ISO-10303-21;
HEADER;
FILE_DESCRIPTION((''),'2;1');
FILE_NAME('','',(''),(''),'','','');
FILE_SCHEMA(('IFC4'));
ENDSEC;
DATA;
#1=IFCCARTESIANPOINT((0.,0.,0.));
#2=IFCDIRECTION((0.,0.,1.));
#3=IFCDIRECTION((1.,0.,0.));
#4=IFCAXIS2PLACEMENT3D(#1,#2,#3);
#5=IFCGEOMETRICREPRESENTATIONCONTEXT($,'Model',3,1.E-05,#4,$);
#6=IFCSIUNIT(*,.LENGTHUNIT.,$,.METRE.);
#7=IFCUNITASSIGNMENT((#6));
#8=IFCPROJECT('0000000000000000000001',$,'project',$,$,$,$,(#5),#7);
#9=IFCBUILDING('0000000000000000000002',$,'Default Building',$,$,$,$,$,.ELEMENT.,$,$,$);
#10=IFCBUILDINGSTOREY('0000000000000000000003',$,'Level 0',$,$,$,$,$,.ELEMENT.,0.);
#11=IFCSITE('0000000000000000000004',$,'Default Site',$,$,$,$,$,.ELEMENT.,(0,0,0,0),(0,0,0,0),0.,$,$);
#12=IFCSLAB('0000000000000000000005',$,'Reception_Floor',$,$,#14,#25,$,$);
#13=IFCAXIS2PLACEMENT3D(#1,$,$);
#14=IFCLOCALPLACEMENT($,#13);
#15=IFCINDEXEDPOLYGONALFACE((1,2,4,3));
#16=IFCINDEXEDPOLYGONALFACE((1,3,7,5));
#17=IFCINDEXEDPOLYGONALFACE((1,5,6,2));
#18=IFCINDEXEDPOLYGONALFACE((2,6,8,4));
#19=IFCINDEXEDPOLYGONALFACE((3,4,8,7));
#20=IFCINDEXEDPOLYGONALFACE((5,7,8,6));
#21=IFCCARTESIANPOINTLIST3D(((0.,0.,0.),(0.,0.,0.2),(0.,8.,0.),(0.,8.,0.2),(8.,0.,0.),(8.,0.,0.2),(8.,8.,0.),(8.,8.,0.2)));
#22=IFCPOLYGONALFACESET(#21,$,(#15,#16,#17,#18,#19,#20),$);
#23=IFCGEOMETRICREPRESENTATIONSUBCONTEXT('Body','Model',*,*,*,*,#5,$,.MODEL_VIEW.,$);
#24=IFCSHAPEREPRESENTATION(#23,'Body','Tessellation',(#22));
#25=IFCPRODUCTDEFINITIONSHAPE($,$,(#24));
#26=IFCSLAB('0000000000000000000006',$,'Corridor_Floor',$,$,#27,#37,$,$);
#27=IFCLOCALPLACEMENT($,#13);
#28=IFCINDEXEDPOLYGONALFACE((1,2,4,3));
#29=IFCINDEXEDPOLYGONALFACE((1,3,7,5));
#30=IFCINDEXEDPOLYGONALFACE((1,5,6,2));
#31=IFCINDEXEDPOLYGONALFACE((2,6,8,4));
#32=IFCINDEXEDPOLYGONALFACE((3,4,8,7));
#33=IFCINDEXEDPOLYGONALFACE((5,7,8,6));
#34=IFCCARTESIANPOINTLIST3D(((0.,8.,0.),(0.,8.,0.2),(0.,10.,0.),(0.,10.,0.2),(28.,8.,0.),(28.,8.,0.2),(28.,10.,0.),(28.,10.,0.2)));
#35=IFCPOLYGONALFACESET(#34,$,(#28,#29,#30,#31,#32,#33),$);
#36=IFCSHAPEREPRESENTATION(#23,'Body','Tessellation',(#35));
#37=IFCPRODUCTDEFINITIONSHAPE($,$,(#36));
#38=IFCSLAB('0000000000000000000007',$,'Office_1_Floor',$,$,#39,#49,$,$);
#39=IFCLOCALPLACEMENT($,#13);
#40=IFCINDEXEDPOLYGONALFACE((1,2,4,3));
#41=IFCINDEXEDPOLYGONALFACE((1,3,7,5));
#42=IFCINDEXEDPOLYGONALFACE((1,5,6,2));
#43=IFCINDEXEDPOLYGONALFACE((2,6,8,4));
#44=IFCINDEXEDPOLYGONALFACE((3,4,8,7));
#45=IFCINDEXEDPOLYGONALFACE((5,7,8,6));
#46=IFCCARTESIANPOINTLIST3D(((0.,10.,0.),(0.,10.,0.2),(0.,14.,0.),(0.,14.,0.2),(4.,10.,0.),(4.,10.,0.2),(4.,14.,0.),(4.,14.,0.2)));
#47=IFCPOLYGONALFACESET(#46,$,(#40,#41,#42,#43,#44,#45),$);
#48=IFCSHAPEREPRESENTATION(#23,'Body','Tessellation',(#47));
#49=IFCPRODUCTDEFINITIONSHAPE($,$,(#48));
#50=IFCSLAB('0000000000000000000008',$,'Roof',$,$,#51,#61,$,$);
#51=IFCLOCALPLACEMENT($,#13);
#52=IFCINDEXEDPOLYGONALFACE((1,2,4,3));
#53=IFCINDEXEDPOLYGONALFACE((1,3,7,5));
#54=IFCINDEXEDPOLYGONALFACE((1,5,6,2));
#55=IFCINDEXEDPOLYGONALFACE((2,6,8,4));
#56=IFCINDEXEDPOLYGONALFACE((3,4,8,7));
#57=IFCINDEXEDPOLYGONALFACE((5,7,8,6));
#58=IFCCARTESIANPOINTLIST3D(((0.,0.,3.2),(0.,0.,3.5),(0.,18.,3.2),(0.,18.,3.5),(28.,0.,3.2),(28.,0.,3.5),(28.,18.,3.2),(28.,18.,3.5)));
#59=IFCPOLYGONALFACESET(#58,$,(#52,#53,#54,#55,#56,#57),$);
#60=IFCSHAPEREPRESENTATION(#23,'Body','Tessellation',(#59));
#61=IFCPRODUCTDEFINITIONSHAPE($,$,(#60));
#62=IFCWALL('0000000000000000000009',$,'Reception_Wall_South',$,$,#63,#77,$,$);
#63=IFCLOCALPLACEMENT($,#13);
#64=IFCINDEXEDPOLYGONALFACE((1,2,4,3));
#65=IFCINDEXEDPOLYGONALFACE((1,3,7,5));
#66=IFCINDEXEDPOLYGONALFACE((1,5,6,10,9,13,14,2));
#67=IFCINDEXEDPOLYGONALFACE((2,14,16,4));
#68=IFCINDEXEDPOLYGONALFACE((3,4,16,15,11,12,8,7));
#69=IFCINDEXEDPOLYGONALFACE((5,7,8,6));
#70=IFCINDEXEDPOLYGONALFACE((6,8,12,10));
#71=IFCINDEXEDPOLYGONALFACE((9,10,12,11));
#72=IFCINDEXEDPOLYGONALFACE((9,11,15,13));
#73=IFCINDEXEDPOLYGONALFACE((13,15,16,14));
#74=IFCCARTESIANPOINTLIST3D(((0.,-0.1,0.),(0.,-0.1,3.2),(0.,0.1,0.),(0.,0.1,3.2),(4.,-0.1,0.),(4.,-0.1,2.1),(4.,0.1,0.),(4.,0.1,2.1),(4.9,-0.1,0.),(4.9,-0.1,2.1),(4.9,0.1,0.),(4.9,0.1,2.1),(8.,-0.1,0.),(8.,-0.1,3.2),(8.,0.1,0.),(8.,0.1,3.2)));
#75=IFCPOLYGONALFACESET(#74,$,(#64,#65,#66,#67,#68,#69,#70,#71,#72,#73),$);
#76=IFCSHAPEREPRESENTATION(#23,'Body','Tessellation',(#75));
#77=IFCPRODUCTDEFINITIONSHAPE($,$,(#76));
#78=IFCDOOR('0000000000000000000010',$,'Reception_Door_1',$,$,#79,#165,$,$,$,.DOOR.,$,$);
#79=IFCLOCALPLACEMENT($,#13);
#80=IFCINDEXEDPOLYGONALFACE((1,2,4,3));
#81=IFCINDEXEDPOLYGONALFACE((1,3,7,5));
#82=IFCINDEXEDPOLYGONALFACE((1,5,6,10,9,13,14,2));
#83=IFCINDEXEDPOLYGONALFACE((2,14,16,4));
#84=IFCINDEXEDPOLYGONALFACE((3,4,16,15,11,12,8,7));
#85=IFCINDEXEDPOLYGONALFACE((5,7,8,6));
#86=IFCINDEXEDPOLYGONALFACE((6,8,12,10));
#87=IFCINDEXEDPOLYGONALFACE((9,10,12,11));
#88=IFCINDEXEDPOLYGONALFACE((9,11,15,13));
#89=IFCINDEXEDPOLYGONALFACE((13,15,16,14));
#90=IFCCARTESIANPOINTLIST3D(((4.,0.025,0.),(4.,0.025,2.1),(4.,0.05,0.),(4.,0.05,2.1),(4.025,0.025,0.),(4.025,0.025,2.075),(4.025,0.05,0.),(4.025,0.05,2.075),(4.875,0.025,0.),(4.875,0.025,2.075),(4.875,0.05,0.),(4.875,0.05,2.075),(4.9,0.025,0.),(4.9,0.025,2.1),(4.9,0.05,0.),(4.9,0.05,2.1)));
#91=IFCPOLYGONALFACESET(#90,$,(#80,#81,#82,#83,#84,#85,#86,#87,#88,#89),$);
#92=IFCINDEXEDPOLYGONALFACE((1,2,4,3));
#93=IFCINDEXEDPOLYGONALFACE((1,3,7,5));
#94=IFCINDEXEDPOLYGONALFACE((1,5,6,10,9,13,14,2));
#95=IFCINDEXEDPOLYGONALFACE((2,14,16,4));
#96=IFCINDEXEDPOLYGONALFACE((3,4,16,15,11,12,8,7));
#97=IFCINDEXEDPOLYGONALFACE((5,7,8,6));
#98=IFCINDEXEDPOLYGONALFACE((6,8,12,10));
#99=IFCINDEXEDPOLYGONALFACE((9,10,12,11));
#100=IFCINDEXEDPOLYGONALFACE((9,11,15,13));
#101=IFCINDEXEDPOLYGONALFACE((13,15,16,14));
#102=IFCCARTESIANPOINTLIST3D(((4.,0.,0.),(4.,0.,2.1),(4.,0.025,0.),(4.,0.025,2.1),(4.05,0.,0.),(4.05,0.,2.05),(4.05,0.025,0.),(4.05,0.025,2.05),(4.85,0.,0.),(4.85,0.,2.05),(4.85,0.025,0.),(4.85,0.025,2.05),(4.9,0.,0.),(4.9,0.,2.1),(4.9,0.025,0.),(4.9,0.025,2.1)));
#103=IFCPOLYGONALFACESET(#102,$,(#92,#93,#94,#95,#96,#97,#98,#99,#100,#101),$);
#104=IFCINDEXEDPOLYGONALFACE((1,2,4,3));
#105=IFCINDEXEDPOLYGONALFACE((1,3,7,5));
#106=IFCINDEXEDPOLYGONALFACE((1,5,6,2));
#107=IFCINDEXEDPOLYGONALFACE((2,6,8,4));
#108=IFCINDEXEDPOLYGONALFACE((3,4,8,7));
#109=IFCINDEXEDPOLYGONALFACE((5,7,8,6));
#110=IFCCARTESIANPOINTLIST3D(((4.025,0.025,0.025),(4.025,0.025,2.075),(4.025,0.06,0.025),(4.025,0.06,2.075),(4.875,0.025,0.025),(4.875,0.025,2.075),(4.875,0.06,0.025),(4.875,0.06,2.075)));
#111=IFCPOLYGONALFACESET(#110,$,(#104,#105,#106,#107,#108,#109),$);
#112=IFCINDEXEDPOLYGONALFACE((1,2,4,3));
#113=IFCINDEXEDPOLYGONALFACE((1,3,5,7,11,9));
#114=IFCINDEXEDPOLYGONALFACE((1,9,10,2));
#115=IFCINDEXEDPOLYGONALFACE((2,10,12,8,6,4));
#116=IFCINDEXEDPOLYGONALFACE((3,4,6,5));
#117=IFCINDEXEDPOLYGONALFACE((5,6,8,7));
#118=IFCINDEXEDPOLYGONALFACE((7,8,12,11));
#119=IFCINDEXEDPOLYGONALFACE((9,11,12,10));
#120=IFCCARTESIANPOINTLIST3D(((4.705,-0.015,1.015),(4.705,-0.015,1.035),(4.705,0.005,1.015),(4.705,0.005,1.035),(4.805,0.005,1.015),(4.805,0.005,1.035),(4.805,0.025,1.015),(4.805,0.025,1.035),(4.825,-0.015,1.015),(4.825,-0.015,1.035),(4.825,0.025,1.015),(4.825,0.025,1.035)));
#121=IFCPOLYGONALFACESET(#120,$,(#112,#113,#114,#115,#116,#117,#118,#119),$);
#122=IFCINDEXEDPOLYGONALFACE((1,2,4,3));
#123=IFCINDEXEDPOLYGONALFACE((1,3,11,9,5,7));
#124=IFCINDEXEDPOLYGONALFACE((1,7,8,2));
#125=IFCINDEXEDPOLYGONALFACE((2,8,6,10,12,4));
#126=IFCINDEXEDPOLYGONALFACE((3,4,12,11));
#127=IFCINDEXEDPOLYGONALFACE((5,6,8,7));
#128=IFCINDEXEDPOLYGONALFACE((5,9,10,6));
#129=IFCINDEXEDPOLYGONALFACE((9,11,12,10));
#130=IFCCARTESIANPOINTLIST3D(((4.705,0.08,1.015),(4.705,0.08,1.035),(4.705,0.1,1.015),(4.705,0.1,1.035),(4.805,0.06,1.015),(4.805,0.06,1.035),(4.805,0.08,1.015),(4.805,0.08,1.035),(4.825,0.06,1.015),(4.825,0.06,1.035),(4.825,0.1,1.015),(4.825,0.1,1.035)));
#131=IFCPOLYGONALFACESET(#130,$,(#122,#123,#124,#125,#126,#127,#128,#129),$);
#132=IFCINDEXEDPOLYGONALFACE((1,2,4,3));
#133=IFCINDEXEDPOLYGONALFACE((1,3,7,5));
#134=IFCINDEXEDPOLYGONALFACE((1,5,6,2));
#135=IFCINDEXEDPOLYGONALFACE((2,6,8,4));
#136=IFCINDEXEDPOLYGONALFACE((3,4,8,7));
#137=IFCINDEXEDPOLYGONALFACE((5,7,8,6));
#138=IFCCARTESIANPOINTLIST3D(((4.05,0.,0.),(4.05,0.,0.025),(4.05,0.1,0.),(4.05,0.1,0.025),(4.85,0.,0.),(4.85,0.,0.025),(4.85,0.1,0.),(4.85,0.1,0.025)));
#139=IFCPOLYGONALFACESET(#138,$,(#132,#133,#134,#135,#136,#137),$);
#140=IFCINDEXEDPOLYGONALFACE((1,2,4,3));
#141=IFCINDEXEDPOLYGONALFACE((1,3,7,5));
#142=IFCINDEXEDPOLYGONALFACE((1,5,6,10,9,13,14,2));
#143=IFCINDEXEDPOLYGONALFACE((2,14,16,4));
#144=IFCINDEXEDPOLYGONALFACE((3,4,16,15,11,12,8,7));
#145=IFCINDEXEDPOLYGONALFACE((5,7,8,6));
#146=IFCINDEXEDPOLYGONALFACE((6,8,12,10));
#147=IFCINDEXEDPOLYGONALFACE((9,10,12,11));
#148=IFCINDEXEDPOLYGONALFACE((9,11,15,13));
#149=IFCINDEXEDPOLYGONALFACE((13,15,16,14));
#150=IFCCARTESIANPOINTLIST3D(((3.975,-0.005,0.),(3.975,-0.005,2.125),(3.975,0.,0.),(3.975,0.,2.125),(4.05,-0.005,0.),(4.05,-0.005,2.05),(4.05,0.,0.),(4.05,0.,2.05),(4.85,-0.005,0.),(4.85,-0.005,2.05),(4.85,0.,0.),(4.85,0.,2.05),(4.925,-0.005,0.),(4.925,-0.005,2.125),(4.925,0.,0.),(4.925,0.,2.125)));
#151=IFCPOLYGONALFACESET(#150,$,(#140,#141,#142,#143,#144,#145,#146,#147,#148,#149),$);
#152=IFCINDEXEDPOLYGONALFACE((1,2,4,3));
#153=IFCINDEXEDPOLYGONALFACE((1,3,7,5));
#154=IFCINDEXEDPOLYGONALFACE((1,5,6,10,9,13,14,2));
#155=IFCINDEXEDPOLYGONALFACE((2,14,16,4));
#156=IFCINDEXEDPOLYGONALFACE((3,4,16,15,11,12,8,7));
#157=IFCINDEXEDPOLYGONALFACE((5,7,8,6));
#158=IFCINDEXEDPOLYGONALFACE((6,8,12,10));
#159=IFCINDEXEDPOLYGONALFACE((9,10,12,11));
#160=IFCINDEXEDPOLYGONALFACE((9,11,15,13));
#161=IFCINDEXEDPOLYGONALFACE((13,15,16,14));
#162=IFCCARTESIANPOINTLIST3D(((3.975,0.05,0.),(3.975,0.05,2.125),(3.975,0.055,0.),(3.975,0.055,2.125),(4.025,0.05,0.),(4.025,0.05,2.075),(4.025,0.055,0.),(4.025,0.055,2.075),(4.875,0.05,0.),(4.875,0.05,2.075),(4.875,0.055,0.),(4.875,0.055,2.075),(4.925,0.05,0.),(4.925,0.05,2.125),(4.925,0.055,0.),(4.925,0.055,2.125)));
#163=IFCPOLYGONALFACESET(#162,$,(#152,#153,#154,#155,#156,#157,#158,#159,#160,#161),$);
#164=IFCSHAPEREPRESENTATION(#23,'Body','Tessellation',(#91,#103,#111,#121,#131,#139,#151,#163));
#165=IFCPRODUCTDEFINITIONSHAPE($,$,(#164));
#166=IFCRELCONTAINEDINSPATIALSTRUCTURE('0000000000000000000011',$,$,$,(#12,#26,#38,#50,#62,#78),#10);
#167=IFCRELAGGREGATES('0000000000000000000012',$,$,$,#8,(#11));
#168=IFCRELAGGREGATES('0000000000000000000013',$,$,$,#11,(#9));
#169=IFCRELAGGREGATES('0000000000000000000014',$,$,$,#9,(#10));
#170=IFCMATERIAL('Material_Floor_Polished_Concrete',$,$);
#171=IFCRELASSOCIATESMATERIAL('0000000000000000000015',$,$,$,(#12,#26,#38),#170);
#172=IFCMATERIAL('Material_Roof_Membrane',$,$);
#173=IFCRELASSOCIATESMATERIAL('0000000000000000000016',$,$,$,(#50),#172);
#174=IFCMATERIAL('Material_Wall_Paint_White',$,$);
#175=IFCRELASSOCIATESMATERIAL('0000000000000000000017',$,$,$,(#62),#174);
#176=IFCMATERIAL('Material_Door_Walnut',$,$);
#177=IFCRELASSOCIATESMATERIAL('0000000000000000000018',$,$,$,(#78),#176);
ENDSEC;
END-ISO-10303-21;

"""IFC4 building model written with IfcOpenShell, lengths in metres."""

from ifc_helpers import new_model, si_unit, frame, origin_with_axes, place, context, subcontext, project, spatial, line, indexed_curve, outline, extrude, material, element, fill, save


model = new_model("IFC4")

# Units and contexts
model_context = context("Model", 3, precision=1e-05, world=origin_with_axes())
body_context = subcontext(model_context, "Body", "Model", "MODEL_VIEW")
ifc_project = project(units=[si_unit("LENGTHUNIT", "METRE")], contexts=[model_context])

# Site, building, storey
site = spatial("IfcSite", under=ifc_project, Name="Default Site", CompositionType="ELEMENT", RefLatitude=(0, 0, 0, 0), RefLongitude=(0, 0, 0, 0), RefElevation=0.0)
building = spatial("IfcBuilding", under=site, Name="Default Building", CompositionType="ELEMENT")
storey = spatial("IfcBuildingStorey", under=building, Name="Level 0", CompositionType="ELEMENT", Elevation=0.0)

# Slabs
ifc_material_1 = material(Name="Material_Floor_Polished_Concrete")
slab_1_placement = place(None, origin_with_axes())
element("IfcSlab", 1, at=slab_1_placement, inside=storey, material=ifc_material_1, Name="Reception_Floor", context=body_context, shape_type="SweptSolid", body=[
    extrude(outline(indexed_curve([(0.0, 0.0), (8.0, 0.0), (8.0, 8.0), (0.0, 8.0)])), None, (0.0, 0.0, 1.0), 0.2),
])
slab_2_placement = place(None, frame((0.0, 8.0, 0.0), z_axis=(0.0, 0.0, 1.0), x_axis=(1.0, 0.0, 0.0)))
element("IfcSlab", 2, at=slab_2_placement, inside=storey, material=ifc_material_1, Name="Corridor_Floor", context=body_context, shape_type="SweptSolid", body=[
    extrude(outline(indexed_curve([(0.0, 0.0), (28.0, 0.0), (28.0, 2.0), (0.0, 2.0)])), None, (0.0, 0.0, 1.0), 0.2),
])
slab_3_placement = place(None, frame((0.0, 10.0, 0.0), z_axis=(0.0, 0.0, 1.0), x_axis=(1.0, 0.0, 0.0)))
element("IfcSlab", 3, at=slab_3_placement, inside=storey, material=ifc_material_1, Name="Office_1_Floor", context=body_context, shape_type="SweptSolid", body=[
    extrude(outline(indexed_curve([(0.0, 0.0), (4.0, 0.0), (4.0, 4.0), (0.0, 4.0)])), None, (0.0, 0.0, 1.0), 0.2),
])
ifc_material_2 = material(Name="Material_Roof_Membrane")
slab_4_placement = place(None, frame((0.0, 0.0, 3.2), z_axis=(0.0, 0.0, 1.0), x_axis=(1.0, 0.0, 0.0)))
element("IfcSlab", 4, at=slab_4_placement, inside=storey, material=ifc_material_2, Name="Roof", context=body_context, shape_type="SweptSolid", body=[
    extrude(outline(indexed_curve([(0.0, 0.0), (28.0, 0.0), (28.0, 18.0), (0.0, 18.0)])), None, (0.0, 0.0, 1.0), 0.3),
])

# Wall, opening, door
ifc_material_3 = material(Name="Material_Wall_Paint_White")
wall_1_placement = place(None, origin_with_axes())
wall_1 = element("IfcWall", 5, at=wall_1_placement, inside=storey, material=ifc_material_3, Name="Reception_Wall_South", context=body_context, shape_type="SweptSolid", body=[
    extrude(outline(indexed_curve([(0.0, 0.0), (0.0, 0.2), (8.0, 0.2), (8.0, 0.0), (0.0, 0.0)], self_intersect=False)), frame((0.0, -0.1, 0.0), z_axis=(0.0, 0.0, 1.0), x_axis=(1.0, 0.0, 0.0)), (0.0, 0.0, 1.0), 3.2),
])
opening_1_placement = place(wall_1_placement, frame((4.0, -0.5, 0.0), z_axis=(0.0, 0.0, 1.0), x_axis=(1.0, 0.0, 0.0)))
opening_1 = element("IfcOpeningElement", 6, at=opening_1_placement, inside=storey, cuts=wall_1, PredefinedType="OPENING", context=body_context, shape_type="SweptSolid", body=[
    extrude(outline(indexed_curve([(0.0, 0.0), (0.0, 1.0), (0.9, 1.0), (0.9, 0.0), (0.0, 0.0)], self_intersect=False)), origin_with_axes(), (0.0, 0.0, 1.0), 2.1),
])
ifc_material_4 = material(Name="Material_Door_Walnut")
door_1_placement = place(None, frame((4.0, 0.0, 0.0), z_axis=(0.0, 0.0, 1.0), x_axis=(1.0, 0.0, 0.0)))
door_1 = element("IfcDoor", 7, at=door_1_placement, inside=storey, material=ifc_material_4, Name="Reception_Door_1", PredefinedType="DOOR", context=body_context, shape_type="SweptSolid", body=[
    extrude(outline(indexed_curve([(0.0, 0.0), (0.0, 2.1), (0.9, 2.1), (0.9, 0.0), (0.875, 0.0), (0.875, 2.075), (0.025, 2.075), (0.025, 0.0)], segments=[line(1, 2, 3, 4, 5, 6, 7, 8, 1)])), frame((0.0, 0.025, 0.0), z_axis=(0.0, -1.0, 0.0), x_axis=(1.0, 0.0, 0.0)), (0.0, 0.0, -1.0), 0.025),
    extrude(outline(indexed_curve([(0.0, 0.0), (0.0, 2.1), (0.9, 2.1), (0.9, 0.0), (0.85, 0.0), (0.85, 2.05), (0.05, 2.05), (0.05, 0.0)], segments=[line(1, 2, 3, 4, 5, 6, 7, 8, 1)])), frame((0.0, 0.0, 0.0), z_axis=(0.0, -1.0, 0.0), x_axis=(1.0, 0.0, 0.0)), (0.0, 0.0, -1.0), 0.025),
    extrude(outline(indexed_curve([(0.0, 0.0), (0.85, 0.0), (0.85, 0.035), (0.0, 0.035)], segments=[line(1, 2, 3, 4, 1)])), frame((0.025, 0.025, 0.025), z_axis=(0.0, 0.0, 1.0), x_axis=(1.0, 0.0, 0.0)), (0.0, 0.0, 1.0), 2.05),
    extrude(outline(indexed_curve([(0.0, 0.0), (0.0, -0.04), (-0.12, -0.04), (-0.12, -0.02), (-0.02, -0.02), (-0.02, 0.0)], segments=[line(1, 2, 3, 4, 5, 6, 1)])), frame((0.825, 0.025, 1.015), z_axis=(0.0, 0.0, 1.0), x_axis=(1.0, 0.0, 0.0)), (0.0, 0.0, 1.0), 0.02),
    extrude(outline(indexed_curve([(0.0, 0.0), (0.0, 0.04), (-0.12, 0.04), (-0.12, 0.02), (-0.02, 0.02), (-0.02, 0.0)], segments=[line(1, 2, 3, 4, 5, 6, 1)])), frame((0.825, 0.06, 1.015), z_axis=(0.0, 0.0, 1.0), x_axis=(1.0, 0.0, 0.0)), (0.0, 0.0, 1.0), 0.02),
    extrude(outline(indexed_curve([(0.0, 0.0), (0.8, 0.0), (0.8, 0.1), (0.0, 0.1)], segments=[line(1, 2, 3, 4, 1)])), frame((0.05, 0.0, 0.0), z_axis=(0.0, 0.0, 1.0), x_axis=(1.0, 0.0, 0.0)), (0.0, 0.0, 1.0), 0.025),
    extrude(outline(indexed_curve([(0.0, 0.0), (0.0, 2.125), (0.95, 2.125), (0.95, 0.0), (0.875, 0.0), (0.875, 2.05), (0.075, 2.05), (0.075, 0.0)], segments=[line(1, 2, 3, 4, 5, 6, 7, 8, 1)])), frame((-0.025, -0.005, 0.0), z_axis=(0.0, -1.0, 0.0), x_axis=(1.0, 0.0, 0.0)), (0.0, 0.0, -1.0), 0.005),
    extrude(outline(indexed_curve([(0.0, 0.0), (0.0, 2.125), (0.95, 2.125), (0.95, 0.0), (0.9, 0.0), (0.9, 2.075), (0.05, 2.075), (0.05, 0.0)], segments=[line(1, 2, 3, 4, 5, 6, 7, 8, 1)])), frame((-0.025, 0.05, 0.0), z_axis=(0.0, -1.0, 0.0), x_axis=(1.0, 0.0, 0.0)), (0.0, 0.0, -1.0), 0.005),
])
fill(opening_1, door_1)

save(model, "model.ifc")
